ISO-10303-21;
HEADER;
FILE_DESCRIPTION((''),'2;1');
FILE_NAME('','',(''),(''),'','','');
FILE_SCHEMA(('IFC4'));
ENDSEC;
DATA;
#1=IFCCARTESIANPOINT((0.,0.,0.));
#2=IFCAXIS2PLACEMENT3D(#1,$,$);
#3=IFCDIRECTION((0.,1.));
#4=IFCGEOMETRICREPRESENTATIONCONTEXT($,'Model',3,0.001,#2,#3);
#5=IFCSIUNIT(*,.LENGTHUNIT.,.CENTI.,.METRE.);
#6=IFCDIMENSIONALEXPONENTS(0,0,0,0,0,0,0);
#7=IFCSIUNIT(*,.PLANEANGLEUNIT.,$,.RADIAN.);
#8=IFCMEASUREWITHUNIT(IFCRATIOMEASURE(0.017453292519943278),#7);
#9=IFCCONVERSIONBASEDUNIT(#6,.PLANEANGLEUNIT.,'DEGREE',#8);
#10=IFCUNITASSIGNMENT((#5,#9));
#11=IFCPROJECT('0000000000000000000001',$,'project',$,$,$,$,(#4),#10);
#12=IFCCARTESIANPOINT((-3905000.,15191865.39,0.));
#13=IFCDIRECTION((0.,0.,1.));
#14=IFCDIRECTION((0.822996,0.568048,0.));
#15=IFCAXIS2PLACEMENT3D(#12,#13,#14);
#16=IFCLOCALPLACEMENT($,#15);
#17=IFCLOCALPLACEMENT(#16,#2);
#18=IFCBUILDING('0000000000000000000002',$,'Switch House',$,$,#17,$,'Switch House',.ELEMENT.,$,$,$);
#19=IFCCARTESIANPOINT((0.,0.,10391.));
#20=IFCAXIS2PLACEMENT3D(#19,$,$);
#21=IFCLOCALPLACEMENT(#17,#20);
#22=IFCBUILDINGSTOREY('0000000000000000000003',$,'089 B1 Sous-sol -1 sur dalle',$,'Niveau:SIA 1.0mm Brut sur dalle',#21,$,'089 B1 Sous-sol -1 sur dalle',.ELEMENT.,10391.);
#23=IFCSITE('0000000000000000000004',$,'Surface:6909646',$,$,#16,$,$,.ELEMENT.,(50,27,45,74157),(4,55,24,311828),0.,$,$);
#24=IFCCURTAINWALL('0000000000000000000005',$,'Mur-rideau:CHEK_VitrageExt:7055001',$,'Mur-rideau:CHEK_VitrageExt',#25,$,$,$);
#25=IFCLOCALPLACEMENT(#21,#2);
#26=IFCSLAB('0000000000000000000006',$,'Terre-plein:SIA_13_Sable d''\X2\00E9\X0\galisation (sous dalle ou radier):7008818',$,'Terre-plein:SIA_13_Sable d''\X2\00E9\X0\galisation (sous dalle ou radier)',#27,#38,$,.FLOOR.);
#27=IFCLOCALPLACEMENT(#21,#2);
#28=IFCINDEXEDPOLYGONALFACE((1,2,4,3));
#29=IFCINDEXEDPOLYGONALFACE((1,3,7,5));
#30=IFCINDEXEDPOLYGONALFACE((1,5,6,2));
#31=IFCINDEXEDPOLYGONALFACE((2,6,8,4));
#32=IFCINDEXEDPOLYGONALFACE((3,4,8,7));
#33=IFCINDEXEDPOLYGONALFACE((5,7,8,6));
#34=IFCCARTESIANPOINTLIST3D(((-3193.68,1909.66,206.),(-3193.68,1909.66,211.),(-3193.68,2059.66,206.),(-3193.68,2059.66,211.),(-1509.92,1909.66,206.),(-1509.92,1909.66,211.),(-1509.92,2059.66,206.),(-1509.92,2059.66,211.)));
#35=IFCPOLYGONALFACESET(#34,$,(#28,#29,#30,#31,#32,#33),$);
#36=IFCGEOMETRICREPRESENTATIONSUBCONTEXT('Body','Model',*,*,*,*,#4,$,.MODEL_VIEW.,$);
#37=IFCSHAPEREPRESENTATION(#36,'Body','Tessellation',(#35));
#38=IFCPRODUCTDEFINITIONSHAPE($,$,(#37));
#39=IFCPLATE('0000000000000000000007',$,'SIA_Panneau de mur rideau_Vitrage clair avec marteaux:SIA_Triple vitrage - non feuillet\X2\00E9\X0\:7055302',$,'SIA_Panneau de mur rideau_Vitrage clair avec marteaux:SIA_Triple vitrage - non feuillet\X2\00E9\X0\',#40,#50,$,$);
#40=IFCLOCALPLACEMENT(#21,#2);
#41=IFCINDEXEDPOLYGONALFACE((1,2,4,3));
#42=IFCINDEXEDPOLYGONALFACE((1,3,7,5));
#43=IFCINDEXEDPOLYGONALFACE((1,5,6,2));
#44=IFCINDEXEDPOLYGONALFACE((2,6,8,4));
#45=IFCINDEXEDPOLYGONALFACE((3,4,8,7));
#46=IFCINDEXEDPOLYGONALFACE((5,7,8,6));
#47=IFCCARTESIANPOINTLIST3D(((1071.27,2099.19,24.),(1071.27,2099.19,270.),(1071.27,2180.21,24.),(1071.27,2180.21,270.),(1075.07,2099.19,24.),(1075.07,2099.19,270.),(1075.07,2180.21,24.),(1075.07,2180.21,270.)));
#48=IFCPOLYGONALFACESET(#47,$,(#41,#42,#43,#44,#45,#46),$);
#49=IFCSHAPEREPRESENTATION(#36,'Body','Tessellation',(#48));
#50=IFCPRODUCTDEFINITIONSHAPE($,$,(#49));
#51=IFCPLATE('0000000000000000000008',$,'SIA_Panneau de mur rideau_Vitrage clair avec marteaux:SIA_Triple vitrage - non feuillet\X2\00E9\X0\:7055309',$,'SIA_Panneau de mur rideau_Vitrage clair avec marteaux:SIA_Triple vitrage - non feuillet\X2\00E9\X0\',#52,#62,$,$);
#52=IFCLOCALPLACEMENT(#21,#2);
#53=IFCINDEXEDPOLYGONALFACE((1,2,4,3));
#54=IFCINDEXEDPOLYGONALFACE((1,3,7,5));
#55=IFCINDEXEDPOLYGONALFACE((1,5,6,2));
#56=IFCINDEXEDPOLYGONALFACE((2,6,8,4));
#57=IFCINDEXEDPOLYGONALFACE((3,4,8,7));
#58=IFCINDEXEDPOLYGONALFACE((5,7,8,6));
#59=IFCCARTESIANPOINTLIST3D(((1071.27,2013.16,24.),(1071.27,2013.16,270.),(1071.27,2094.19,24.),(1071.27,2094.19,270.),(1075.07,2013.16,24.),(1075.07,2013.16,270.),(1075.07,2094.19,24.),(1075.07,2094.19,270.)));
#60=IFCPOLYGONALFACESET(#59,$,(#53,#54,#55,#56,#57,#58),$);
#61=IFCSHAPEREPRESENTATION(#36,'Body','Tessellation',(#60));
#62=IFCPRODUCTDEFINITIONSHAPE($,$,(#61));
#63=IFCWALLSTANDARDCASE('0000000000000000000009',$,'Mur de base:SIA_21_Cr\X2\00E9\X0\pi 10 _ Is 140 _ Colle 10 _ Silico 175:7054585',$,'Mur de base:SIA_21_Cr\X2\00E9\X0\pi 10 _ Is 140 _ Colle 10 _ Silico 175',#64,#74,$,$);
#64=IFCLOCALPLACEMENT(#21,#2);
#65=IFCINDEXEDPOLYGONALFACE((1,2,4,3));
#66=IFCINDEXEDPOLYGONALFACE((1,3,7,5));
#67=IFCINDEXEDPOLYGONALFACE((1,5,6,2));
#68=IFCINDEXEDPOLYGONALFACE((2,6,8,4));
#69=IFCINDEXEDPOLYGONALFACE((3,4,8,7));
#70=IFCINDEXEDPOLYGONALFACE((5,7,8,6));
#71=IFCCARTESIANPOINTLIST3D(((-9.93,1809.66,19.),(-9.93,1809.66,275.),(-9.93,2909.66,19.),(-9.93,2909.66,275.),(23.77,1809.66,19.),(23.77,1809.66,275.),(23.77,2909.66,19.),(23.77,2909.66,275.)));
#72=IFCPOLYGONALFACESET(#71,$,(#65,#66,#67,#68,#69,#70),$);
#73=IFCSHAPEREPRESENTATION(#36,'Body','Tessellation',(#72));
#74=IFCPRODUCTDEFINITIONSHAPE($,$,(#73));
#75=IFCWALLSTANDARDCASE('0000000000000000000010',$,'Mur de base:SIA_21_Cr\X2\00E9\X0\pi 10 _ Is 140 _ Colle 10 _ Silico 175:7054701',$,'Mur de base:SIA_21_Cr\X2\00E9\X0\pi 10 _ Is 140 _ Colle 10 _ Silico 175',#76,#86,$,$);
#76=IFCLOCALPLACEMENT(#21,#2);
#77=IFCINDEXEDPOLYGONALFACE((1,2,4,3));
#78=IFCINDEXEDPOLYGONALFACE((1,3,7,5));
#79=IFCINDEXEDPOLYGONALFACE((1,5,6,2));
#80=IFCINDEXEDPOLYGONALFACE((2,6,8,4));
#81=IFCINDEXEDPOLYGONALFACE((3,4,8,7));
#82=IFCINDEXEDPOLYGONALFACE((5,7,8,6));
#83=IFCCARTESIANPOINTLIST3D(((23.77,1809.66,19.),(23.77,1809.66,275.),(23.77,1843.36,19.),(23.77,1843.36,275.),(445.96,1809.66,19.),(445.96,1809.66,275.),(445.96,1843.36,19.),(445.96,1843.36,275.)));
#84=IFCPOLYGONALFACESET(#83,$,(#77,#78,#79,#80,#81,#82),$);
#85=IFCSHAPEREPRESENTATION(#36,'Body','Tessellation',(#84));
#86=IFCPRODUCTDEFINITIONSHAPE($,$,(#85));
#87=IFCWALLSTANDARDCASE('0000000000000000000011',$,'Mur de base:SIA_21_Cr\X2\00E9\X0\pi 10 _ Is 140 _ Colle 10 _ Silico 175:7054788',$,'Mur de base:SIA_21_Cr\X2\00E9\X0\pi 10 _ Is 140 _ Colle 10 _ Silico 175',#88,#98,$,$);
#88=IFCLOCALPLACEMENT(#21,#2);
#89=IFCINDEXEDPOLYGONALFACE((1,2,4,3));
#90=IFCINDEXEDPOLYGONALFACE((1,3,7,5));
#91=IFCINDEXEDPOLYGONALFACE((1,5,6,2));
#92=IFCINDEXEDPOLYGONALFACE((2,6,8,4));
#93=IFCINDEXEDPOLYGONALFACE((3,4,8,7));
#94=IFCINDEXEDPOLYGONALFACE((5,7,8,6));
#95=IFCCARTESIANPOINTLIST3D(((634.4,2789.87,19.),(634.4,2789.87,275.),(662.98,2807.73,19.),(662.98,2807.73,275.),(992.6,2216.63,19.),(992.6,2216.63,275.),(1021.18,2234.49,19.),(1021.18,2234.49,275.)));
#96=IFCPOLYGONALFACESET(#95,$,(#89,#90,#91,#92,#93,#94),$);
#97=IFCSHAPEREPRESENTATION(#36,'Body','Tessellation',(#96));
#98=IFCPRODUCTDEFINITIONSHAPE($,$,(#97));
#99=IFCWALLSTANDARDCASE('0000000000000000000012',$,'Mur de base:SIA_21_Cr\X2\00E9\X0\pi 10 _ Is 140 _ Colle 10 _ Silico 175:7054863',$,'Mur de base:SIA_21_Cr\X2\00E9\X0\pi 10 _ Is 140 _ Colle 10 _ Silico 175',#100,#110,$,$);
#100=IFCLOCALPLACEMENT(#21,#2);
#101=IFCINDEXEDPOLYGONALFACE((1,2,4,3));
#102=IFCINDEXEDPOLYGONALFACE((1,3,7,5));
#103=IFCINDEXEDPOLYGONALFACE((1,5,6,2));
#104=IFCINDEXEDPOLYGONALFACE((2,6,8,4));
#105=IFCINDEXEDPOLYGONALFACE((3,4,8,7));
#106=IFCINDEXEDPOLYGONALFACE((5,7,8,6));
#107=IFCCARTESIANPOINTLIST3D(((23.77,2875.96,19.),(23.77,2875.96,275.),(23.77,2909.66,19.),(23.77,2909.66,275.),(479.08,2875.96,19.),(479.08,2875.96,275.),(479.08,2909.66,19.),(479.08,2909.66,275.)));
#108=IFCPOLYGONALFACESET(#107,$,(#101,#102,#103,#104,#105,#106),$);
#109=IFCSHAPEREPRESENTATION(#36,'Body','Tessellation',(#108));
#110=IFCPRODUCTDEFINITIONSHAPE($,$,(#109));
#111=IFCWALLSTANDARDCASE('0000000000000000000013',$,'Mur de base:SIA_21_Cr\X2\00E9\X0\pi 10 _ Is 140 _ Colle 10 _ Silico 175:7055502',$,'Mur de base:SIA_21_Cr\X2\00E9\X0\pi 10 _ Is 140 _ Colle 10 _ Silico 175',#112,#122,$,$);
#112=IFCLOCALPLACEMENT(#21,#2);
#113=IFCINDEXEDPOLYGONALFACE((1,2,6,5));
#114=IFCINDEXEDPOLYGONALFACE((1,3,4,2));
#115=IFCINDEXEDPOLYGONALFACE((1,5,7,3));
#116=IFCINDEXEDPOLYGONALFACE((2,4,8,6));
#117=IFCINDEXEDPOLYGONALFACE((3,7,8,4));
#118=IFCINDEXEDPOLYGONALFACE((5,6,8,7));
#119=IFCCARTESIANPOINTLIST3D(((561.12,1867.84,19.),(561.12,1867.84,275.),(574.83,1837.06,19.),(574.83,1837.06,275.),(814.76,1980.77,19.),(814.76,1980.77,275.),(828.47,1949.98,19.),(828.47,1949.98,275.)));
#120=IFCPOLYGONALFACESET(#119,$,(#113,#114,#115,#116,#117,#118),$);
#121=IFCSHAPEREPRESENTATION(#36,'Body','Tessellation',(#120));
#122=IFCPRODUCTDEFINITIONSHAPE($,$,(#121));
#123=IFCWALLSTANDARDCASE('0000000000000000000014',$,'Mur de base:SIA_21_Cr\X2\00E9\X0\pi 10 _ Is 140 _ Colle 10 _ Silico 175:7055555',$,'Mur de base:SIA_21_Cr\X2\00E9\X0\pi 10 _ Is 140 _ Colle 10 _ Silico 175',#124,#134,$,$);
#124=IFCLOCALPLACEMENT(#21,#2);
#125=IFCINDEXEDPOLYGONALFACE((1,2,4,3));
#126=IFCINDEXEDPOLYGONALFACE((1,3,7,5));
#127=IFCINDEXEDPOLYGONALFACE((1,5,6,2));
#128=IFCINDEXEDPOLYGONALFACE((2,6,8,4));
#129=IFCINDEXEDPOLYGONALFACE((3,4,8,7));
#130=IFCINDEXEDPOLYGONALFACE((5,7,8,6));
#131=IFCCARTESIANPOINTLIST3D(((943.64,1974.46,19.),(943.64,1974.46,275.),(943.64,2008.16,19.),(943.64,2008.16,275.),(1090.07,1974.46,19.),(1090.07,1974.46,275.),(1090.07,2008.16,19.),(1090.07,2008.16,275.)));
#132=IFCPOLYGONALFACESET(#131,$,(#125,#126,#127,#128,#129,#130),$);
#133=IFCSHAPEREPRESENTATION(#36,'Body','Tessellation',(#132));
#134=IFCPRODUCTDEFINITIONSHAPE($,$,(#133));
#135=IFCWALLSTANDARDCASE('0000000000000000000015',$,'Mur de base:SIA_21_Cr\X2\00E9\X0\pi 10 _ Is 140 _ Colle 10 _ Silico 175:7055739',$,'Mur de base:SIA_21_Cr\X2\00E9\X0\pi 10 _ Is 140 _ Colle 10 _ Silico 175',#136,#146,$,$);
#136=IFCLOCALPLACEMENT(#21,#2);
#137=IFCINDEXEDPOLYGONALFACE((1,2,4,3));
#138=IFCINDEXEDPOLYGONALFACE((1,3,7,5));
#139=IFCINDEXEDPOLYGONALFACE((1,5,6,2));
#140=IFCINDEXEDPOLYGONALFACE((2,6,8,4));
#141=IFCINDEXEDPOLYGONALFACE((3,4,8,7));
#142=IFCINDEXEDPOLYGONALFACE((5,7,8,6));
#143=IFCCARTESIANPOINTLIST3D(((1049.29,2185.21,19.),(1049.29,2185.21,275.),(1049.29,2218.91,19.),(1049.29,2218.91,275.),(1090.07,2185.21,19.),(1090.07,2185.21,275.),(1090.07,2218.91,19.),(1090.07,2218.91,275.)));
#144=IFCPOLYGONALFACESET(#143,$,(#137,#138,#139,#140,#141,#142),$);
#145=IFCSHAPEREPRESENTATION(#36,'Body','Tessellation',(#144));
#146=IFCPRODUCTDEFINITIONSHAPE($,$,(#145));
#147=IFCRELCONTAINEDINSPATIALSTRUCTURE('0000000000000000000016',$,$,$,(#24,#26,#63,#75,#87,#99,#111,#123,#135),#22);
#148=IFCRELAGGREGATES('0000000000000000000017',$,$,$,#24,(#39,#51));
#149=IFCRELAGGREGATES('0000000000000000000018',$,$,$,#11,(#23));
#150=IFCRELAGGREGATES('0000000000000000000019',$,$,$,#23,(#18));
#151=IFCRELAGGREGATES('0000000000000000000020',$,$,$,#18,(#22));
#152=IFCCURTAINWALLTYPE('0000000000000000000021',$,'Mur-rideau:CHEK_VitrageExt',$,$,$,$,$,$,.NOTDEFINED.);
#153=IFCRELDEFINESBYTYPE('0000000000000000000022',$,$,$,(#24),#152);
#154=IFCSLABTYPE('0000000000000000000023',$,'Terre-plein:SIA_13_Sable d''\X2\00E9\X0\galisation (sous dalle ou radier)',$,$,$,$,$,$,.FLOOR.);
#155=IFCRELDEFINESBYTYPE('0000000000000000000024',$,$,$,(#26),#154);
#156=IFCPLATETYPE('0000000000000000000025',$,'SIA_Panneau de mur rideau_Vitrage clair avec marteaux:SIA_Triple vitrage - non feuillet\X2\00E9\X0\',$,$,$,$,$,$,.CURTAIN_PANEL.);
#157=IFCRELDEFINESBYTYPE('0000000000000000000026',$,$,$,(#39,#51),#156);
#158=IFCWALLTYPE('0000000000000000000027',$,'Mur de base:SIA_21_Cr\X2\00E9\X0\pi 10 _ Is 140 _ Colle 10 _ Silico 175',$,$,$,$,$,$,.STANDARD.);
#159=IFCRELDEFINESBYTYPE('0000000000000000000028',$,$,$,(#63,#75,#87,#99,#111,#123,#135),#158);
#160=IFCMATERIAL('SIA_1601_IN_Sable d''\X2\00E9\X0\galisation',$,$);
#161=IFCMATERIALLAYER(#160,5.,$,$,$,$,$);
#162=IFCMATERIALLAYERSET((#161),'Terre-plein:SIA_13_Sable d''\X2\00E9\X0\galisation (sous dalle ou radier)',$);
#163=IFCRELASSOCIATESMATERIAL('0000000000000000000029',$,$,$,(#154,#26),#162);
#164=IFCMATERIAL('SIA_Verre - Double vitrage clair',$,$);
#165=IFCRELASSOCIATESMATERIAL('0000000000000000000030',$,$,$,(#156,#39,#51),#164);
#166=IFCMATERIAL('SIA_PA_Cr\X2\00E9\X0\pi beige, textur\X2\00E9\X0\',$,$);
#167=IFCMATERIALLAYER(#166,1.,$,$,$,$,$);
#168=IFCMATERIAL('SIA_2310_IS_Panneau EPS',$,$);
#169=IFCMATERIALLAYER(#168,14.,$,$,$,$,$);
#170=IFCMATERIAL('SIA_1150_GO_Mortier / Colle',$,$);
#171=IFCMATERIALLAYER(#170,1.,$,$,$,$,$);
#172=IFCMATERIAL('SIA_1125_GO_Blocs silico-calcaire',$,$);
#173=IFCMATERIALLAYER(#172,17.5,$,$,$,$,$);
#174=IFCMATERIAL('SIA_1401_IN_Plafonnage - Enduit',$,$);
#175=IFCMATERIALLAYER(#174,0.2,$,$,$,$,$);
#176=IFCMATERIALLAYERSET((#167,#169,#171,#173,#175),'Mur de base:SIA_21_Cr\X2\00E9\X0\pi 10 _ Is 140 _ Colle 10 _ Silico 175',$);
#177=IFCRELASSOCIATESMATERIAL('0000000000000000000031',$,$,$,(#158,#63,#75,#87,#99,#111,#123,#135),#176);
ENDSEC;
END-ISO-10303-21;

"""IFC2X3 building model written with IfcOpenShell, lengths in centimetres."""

from ifc_helpers import new_model, entity, si_unit, converted_unit, direction, frame, frame_2d, origin, origin_2d_with_axis, place, context, subcontext, project, spatial, rectangle, extrude, source, transform, mapped, material, layer, layer_set, layer_usage, type_object, type_shapes, element, aggregate, save


model = new_model("IFC2X3")

# Units and contexts
model_context = context("Model", 3, precision=0.001, world=origin(), true_north=direction((0.0, 1.0)))
body_context = subcontext(model_context, "Body", "Model", "MODEL_VIEW")
ifc_project = project(units=[si_unit("LENGTHUNIT", "METRE", prefix="CENTI"), converted_unit("PLANEANGLEUNIT", "DEGREE", entity("IfcRatioMeasure", 0.017453292519943278), si_unit("PLANEANGLEUNIT", "RADIAN"), dimensions=[0, 0, 0, 0, 0, 0, 0])], contexts=[model_context])

# Site, building, storey
site_placement = place(None, frame((-3905000.0, 15191865.39, 0.0), z_axis=(0.0, 0.0, 1.0), x_axis=(0.822996, 0.568048, 0.0)))
site = spatial("IfcSite", under=ifc_project, at=site_placement, Name="Surface:6909646", CompositionType="ELEMENT", RefLatitude=(50, 27, 45, 74157), RefLongitude=(4, 55, 24, 311828), RefElevation=0.0)
building_placement = place(site_placement, origin())
building = spatial("IfcBuilding", under=site, at=building_placement, Name="Switch House", LongName="Switch House", CompositionType="ELEMENT")
storey_placement = place(building_placement, frame((0.0, 0.0, 10391.0)))
storey = spatial("IfcBuildingStorey", under=building, at=storey_placement, Name="089 B1 Sous-sol -1 sur dalle", ObjectType="Niveau:SIA 1.0mm Brut sur dalle", LongName="089 B1 Sous-sol -1 sur dalle", CompositionType="ELEMENT", Elevation=10391.0)

# Curtain wall
curtain_wall_type = type_object("IfcCurtainWallType", Name="Mur-rideau:CHEK_VitrageExt", PredefinedType="NOTDEFINED")
curtain_wall_placement = place(storey_placement, frame((0.0, 0.0, -10391.0)))
curtain_wall = element("IfcCurtainWall", 1, at=curtain_wall_placement, inside=storey, type_object=curtain_wall_type, Name="Mur-rideau:CHEK_VitrageExt:7055001", ObjectType="Mur-rideau:CHEK_VitrageExt")

# Slab
ifc_material_1 = material(Name="SIA_1601_IN_Sable d'égalisation")
ifc_layer_1 = layer(ifc_material_1, 5.0)
ifc_layer_set_1 = layer_set([ifc_layer_1], Name="Terre-plein:SIA_13_Sable d'égalisation (sous dalle ou radier)")
ifc_layer_usage_1 = layer_usage(ifc_layer_set_1, "AXIS3", "POSITIVE", 0.0)
slab_type = type_object("IfcSlabType", Name="Terre-plein:SIA_13_Sable d'égalisation (sous dalle ou radier)", PredefinedType="FLOOR", material=ifc_layer_set_1)
slab_placement = place(storey_placement, origin())
element("IfcSlab", 2, at=slab_placement, inside=storey, type_object=slab_type, material=ifc_layer_usage_1, Name="Terre-plein:SIA_13_Sable d'égalisation (sous dalle ou radier):7008818", ObjectType="Terre-plein:SIA_13_Sable d'égalisation (sous dalle ou radier)", PredefinedType="FLOOR", context=body_context, shape_type="SweptSolid", body=[
    extrude(rectangle(XDim=150.0, YDim=1683.75, at=frame_2d((0.0, 0.0), x_axis=(1.0, 0.0))), frame((-2351.8, 1984.66, 206.0), z_axis=(0.0, 0.0, 1.0), x_axis=(0.0, 1.0, 0.0)), (0.0, 0.0, 1.0), 5.0),
])

# Plates
ifc_material_2 = material(Name="SIA_Verre - Double vitrage clair")
plate_type = type_object("IfcPlateType", Name="SIA_Panneau de mur rideau_Vitrage clair avec marteaux:SIA_Triple vitrage - non feuilleté", PredefinedType="CURTAIN_PANEL", material=ifc_material_2)
shared_shape_1 = source(origin(), body_context, "Body", "SweptSolid", [
    extrude(rectangle(XDim=3.8, YDim=81.02, at=origin_2d_with_axis()), frame((0.0, -1.9, 0.0), z_axis=(0.0, 0.0, 1.0), x_axis=(0.0, 1.0, 0.0)), (0.0, 0.0, 1.0), 246.0),
])
type_shapes(plate_type, [shared_shape_1])
plate_1_placement = place(curtain_wall_placement, frame((1075.07, 2139.7, 10415.0), z_axis=(0.0, 0.0, 1.0), x_axis=(0.0, -1.0, 0.0)))
plate_1 = element("IfcPlate", 3, at=plate_1_placement, type_object=plate_type, material=ifc_material_2, Name="SIA_Panneau de mur rideau_Vitrage clair avec marteaux:SIA_Triple vitrage - non feuilleté:7055302", ObjectType="SIA_Panneau de mur rideau_Vitrage clair avec marteaux:SIA_Triple vitrage - non feuilleté", context=body_context, shape_type="MappedRepresentation", body=[
    mapped(shared_shape_1, transform((0.0, 0.0, 0.0), scale=1.0)),
])
plate_2_placement = place(curtain_wall_placement, frame((1075.07, 2053.67, 10415.0), z_axis=(0.0, 0.0, 1.0), x_axis=(0.0, -1.0, 0.0)))
plate_2 = element("IfcPlate", 4, at=plate_2_placement, type_object=plate_type, material=ifc_material_2, Name="SIA_Panneau de mur rideau_Vitrage clair avec marteaux:SIA_Triple vitrage - non feuilleté:7055309", ObjectType="SIA_Panneau de mur rideau_Vitrage clair avec marteaux:SIA_Triple vitrage - non feuilleté", context=body_context, shape_type="MappedRepresentation", body=[
    mapped(shared_shape_1, transform((0.0, 0.0, 0.0), scale=1.0)),
])
aggregate(curtain_wall, [plate_1, plate_2])

# Walls
ifc_material_3 = material(Name="SIA_PA_Crépi beige, texturé")
ifc_layer_2 = layer(ifc_material_3, 1.0)
ifc_material_4 = material(Name="SIA_2310_IS_Panneau EPS")
ifc_layer_3 = layer(ifc_material_4, 14.0)
ifc_material_5 = material(Name="SIA_1150_GO_Mortier / Colle")
ifc_layer_4 = layer(ifc_material_5, 1.0)
ifc_material_6 = material(Name="SIA_1125_GO_Blocs silico-calcaire")
ifc_layer_5 = layer(ifc_material_6, 17.5)
ifc_material_7 = material(Name="SIA_1401_IN_Plafonnage - Enduit")
ifc_layer_6 = layer(ifc_material_7, 0.2)
ifc_layer_set_2 = layer_set([ifc_layer_2, ifc_layer_3, ifc_layer_4, ifc_layer_5, ifc_layer_6], Name="Mur de base:SIA_21_Crépi 10 _ Is 140 _ Colle 10 _ Silico 175")
ifc_layer_usage_2 = layer_usage(ifc_layer_set_2, "AXIS2", "POSITIVE", -16.85)
wall_type = type_object("IfcWallType", Name="Mur de base:SIA_21_Crépi 10 _ Is 140 _ Colle 10 _ Silico 175", PredefinedType="STANDARD", material=ifc_layer_set_2)
wall_1_placement = place(storey_placement, frame((6.92, 2909.66, 19.0), z_axis=(0.0, 0.0, 1.0), x_axis=(0.0, -1.0, 0.0)))
element("IfcWallStandardCase", 5, at=wall_1_placement, inside=storey, type_object=wall_type, material=ifc_layer_usage_2, Name="Mur de base:SIA_21_Crépi 10 _ Is 140 _ Colle 10 _ Silico 175:7054585", ObjectType="Mur de base:SIA_21_Crépi 10 _ Is 140 _ Colle 10 _ Silico 175", context=body_context, shape_type="SweptSolid", body=[
    extrude(rectangle(XDim=1100.0, YDim=33.7, at=frame_2d((550.0, 0.0), x_axis=(-1.0, 0.0))), origin(), (0.0, 0.0, 1.0), 256.0),
])
wall_2_placement = place(storey_placement, frame((23.77, 1826.51, 19.0)))
element("IfcWallStandardCase", 6, at=wall_2_placement, inside=storey, type_object=wall_type, material=ifc_layer_usage_2, Name="Mur de base:SIA_21_Crépi 10 _ Is 140 _ Colle 10 _ Silico 175:7054701", ObjectType="Mur de base:SIA_21_Crépi 10 _ Is 140 _ Colle 10 _ Silico 175", context=body_context, shape_type="SweptSolid", body=[
    extrude(rectangle(XDim=422.19, YDim=33.7, at=frame_2d((211.09, 0.0), x_axis=(-1.0, 0.0))), origin(), (0.0, 0.0, 1.0), 256.0),
])
wall_3_placement = place(storey_placement, frame((1006.89, 2225.56, 19.0), z_axis=(0.0, 0.0, 1.0), x_axis=(-0.529919, 0.848048, 0.0)))
element("IfcWallStandardCase", 7, at=wall_3_placement, inside=storey, type_object=wall_type, material=ifc_layer_usage_2, Name="Mur de base:SIA_21_Crépi 10 _ Is 140 _ Colle 10 _ Silico 175:7054788", ObjectType="Mur de base:SIA_21_Crépi 10 _ Is 140 _ Colle 10 _ Silico 175", context=body_context, shape_type="SweptSolid", body=[
    extrude(rectangle(XDim=675.94, YDim=33.7, at=frame_2d((337.97, 0.0), x_axis=(-1.0, 0.0))), origin(), (0.0, 0.0, 1.0), 256.0),
])
wall_4_placement = place(storey_placement, frame((479.08, 2892.81, 19.0), z_axis=(0.0, 0.0, 1.0), x_axis=(-1.0, 0.0, 0.0)))
element("IfcWallStandardCase", 8, at=wall_4_placement, inside=storey, type_object=wall_type, material=ifc_layer_usage_2, Name="Mur de base:SIA_21_Crépi 10 _ Is 140 _ Colle 10 _ Silico 175:7054863", ObjectType="Mur de base:SIA_21_Crépi 10 _ Is 140 _ Colle 10 _ Silico 175", context=body_context, shape_type="SweptSolid", body=[
    extrude(rectangle(XDim=455.31, YDim=33.7, at=frame_2d((227.66, 0.0), x_axis=(-1.0, 0.0))), origin(), (0.0, 0.0, 1.0), 256.0),
])
wall_5_placement = place(storey_placement, frame((567.98, 1852.45, 19.0), z_axis=(0.0, 0.0, 1.0), x_axis=(0.913545, 0.406737, 0.0)))
element("IfcWallStandardCase", 9, at=wall_5_placement, inside=storey, type_object=wall_type, material=ifc_layer_usage_2, Name="Mur de base:SIA_21_Crépi 10 _ Is 140 _ Colle 10 _ Silico 175:7055502", ObjectType="Mur de base:SIA_21_Crépi 10 _ Is 140 _ Colle 10 _ Silico 175", context=body_context, shape_type="SweptSolid", body=[
    extrude(rectangle(XDim=277.64, YDim=33.7, at=frame_2d((138.82, 0.0), x_axis=(-1.0, 0.0))), origin(), (0.0, 0.0, 1.0), 256.0),
])
wall_6_placement = place(storey_placement, frame((943.64, 1991.31, 19.0)))
element("IfcWallStandardCase", 10, at=wall_6_placement, inside=storey, type_object=wall_type, material=ifc_layer_usage_2, Name="Mur de base:SIA_21_Crépi 10 _ Is 140 _ Colle 10 _ Silico 175:7055555", ObjectType="Mur de base:SIA_21_Crépi 10 _ Is 140 _ Colle 10 _ Silico 175", context=body_context, shape_type="SweptSolid", body=[
    extrude(rectangle(XDim=146.43, YDim=33.7, at=frame_2d((73.22, 0.0), x_axis=(-1.0, 0.0))), origin(), (0.0, 0.0, 1.0), 256.0),
])
ifc_layer_usage_3 = layer_usage(ifc_layer_set_2, "AXIS2", "NEGATIVE", 16.85)
wall_7_placement = place(storey_placement, frame((1049.29, 2202.06, 19.0)))
element("IfcWallStandardCase", 11, at=wall_7_placement, inside=storey, type_object=wall_type, material=ifc_layer_usage_3, Name="Mur de base:SIA_21_Crépi 10 _ Is 140 _ Colle 10 _ Silico 175:7055739", ObjectType="Mur de base:SIA_21_Crépi 10 _ Is 140 _ Colle 10 _ Silico 175", context=body_context, shape_type="SweptSolid", body=[
    extrude(rectangle(XDim=40.78, YDim=33.7, at=frame_2d((20.39, 0.0), x_axis=(-1.0, 0.0))), origin(), (0.0, 0.0, 1.0), 256.0),
])

save(model, "model.ifc")
